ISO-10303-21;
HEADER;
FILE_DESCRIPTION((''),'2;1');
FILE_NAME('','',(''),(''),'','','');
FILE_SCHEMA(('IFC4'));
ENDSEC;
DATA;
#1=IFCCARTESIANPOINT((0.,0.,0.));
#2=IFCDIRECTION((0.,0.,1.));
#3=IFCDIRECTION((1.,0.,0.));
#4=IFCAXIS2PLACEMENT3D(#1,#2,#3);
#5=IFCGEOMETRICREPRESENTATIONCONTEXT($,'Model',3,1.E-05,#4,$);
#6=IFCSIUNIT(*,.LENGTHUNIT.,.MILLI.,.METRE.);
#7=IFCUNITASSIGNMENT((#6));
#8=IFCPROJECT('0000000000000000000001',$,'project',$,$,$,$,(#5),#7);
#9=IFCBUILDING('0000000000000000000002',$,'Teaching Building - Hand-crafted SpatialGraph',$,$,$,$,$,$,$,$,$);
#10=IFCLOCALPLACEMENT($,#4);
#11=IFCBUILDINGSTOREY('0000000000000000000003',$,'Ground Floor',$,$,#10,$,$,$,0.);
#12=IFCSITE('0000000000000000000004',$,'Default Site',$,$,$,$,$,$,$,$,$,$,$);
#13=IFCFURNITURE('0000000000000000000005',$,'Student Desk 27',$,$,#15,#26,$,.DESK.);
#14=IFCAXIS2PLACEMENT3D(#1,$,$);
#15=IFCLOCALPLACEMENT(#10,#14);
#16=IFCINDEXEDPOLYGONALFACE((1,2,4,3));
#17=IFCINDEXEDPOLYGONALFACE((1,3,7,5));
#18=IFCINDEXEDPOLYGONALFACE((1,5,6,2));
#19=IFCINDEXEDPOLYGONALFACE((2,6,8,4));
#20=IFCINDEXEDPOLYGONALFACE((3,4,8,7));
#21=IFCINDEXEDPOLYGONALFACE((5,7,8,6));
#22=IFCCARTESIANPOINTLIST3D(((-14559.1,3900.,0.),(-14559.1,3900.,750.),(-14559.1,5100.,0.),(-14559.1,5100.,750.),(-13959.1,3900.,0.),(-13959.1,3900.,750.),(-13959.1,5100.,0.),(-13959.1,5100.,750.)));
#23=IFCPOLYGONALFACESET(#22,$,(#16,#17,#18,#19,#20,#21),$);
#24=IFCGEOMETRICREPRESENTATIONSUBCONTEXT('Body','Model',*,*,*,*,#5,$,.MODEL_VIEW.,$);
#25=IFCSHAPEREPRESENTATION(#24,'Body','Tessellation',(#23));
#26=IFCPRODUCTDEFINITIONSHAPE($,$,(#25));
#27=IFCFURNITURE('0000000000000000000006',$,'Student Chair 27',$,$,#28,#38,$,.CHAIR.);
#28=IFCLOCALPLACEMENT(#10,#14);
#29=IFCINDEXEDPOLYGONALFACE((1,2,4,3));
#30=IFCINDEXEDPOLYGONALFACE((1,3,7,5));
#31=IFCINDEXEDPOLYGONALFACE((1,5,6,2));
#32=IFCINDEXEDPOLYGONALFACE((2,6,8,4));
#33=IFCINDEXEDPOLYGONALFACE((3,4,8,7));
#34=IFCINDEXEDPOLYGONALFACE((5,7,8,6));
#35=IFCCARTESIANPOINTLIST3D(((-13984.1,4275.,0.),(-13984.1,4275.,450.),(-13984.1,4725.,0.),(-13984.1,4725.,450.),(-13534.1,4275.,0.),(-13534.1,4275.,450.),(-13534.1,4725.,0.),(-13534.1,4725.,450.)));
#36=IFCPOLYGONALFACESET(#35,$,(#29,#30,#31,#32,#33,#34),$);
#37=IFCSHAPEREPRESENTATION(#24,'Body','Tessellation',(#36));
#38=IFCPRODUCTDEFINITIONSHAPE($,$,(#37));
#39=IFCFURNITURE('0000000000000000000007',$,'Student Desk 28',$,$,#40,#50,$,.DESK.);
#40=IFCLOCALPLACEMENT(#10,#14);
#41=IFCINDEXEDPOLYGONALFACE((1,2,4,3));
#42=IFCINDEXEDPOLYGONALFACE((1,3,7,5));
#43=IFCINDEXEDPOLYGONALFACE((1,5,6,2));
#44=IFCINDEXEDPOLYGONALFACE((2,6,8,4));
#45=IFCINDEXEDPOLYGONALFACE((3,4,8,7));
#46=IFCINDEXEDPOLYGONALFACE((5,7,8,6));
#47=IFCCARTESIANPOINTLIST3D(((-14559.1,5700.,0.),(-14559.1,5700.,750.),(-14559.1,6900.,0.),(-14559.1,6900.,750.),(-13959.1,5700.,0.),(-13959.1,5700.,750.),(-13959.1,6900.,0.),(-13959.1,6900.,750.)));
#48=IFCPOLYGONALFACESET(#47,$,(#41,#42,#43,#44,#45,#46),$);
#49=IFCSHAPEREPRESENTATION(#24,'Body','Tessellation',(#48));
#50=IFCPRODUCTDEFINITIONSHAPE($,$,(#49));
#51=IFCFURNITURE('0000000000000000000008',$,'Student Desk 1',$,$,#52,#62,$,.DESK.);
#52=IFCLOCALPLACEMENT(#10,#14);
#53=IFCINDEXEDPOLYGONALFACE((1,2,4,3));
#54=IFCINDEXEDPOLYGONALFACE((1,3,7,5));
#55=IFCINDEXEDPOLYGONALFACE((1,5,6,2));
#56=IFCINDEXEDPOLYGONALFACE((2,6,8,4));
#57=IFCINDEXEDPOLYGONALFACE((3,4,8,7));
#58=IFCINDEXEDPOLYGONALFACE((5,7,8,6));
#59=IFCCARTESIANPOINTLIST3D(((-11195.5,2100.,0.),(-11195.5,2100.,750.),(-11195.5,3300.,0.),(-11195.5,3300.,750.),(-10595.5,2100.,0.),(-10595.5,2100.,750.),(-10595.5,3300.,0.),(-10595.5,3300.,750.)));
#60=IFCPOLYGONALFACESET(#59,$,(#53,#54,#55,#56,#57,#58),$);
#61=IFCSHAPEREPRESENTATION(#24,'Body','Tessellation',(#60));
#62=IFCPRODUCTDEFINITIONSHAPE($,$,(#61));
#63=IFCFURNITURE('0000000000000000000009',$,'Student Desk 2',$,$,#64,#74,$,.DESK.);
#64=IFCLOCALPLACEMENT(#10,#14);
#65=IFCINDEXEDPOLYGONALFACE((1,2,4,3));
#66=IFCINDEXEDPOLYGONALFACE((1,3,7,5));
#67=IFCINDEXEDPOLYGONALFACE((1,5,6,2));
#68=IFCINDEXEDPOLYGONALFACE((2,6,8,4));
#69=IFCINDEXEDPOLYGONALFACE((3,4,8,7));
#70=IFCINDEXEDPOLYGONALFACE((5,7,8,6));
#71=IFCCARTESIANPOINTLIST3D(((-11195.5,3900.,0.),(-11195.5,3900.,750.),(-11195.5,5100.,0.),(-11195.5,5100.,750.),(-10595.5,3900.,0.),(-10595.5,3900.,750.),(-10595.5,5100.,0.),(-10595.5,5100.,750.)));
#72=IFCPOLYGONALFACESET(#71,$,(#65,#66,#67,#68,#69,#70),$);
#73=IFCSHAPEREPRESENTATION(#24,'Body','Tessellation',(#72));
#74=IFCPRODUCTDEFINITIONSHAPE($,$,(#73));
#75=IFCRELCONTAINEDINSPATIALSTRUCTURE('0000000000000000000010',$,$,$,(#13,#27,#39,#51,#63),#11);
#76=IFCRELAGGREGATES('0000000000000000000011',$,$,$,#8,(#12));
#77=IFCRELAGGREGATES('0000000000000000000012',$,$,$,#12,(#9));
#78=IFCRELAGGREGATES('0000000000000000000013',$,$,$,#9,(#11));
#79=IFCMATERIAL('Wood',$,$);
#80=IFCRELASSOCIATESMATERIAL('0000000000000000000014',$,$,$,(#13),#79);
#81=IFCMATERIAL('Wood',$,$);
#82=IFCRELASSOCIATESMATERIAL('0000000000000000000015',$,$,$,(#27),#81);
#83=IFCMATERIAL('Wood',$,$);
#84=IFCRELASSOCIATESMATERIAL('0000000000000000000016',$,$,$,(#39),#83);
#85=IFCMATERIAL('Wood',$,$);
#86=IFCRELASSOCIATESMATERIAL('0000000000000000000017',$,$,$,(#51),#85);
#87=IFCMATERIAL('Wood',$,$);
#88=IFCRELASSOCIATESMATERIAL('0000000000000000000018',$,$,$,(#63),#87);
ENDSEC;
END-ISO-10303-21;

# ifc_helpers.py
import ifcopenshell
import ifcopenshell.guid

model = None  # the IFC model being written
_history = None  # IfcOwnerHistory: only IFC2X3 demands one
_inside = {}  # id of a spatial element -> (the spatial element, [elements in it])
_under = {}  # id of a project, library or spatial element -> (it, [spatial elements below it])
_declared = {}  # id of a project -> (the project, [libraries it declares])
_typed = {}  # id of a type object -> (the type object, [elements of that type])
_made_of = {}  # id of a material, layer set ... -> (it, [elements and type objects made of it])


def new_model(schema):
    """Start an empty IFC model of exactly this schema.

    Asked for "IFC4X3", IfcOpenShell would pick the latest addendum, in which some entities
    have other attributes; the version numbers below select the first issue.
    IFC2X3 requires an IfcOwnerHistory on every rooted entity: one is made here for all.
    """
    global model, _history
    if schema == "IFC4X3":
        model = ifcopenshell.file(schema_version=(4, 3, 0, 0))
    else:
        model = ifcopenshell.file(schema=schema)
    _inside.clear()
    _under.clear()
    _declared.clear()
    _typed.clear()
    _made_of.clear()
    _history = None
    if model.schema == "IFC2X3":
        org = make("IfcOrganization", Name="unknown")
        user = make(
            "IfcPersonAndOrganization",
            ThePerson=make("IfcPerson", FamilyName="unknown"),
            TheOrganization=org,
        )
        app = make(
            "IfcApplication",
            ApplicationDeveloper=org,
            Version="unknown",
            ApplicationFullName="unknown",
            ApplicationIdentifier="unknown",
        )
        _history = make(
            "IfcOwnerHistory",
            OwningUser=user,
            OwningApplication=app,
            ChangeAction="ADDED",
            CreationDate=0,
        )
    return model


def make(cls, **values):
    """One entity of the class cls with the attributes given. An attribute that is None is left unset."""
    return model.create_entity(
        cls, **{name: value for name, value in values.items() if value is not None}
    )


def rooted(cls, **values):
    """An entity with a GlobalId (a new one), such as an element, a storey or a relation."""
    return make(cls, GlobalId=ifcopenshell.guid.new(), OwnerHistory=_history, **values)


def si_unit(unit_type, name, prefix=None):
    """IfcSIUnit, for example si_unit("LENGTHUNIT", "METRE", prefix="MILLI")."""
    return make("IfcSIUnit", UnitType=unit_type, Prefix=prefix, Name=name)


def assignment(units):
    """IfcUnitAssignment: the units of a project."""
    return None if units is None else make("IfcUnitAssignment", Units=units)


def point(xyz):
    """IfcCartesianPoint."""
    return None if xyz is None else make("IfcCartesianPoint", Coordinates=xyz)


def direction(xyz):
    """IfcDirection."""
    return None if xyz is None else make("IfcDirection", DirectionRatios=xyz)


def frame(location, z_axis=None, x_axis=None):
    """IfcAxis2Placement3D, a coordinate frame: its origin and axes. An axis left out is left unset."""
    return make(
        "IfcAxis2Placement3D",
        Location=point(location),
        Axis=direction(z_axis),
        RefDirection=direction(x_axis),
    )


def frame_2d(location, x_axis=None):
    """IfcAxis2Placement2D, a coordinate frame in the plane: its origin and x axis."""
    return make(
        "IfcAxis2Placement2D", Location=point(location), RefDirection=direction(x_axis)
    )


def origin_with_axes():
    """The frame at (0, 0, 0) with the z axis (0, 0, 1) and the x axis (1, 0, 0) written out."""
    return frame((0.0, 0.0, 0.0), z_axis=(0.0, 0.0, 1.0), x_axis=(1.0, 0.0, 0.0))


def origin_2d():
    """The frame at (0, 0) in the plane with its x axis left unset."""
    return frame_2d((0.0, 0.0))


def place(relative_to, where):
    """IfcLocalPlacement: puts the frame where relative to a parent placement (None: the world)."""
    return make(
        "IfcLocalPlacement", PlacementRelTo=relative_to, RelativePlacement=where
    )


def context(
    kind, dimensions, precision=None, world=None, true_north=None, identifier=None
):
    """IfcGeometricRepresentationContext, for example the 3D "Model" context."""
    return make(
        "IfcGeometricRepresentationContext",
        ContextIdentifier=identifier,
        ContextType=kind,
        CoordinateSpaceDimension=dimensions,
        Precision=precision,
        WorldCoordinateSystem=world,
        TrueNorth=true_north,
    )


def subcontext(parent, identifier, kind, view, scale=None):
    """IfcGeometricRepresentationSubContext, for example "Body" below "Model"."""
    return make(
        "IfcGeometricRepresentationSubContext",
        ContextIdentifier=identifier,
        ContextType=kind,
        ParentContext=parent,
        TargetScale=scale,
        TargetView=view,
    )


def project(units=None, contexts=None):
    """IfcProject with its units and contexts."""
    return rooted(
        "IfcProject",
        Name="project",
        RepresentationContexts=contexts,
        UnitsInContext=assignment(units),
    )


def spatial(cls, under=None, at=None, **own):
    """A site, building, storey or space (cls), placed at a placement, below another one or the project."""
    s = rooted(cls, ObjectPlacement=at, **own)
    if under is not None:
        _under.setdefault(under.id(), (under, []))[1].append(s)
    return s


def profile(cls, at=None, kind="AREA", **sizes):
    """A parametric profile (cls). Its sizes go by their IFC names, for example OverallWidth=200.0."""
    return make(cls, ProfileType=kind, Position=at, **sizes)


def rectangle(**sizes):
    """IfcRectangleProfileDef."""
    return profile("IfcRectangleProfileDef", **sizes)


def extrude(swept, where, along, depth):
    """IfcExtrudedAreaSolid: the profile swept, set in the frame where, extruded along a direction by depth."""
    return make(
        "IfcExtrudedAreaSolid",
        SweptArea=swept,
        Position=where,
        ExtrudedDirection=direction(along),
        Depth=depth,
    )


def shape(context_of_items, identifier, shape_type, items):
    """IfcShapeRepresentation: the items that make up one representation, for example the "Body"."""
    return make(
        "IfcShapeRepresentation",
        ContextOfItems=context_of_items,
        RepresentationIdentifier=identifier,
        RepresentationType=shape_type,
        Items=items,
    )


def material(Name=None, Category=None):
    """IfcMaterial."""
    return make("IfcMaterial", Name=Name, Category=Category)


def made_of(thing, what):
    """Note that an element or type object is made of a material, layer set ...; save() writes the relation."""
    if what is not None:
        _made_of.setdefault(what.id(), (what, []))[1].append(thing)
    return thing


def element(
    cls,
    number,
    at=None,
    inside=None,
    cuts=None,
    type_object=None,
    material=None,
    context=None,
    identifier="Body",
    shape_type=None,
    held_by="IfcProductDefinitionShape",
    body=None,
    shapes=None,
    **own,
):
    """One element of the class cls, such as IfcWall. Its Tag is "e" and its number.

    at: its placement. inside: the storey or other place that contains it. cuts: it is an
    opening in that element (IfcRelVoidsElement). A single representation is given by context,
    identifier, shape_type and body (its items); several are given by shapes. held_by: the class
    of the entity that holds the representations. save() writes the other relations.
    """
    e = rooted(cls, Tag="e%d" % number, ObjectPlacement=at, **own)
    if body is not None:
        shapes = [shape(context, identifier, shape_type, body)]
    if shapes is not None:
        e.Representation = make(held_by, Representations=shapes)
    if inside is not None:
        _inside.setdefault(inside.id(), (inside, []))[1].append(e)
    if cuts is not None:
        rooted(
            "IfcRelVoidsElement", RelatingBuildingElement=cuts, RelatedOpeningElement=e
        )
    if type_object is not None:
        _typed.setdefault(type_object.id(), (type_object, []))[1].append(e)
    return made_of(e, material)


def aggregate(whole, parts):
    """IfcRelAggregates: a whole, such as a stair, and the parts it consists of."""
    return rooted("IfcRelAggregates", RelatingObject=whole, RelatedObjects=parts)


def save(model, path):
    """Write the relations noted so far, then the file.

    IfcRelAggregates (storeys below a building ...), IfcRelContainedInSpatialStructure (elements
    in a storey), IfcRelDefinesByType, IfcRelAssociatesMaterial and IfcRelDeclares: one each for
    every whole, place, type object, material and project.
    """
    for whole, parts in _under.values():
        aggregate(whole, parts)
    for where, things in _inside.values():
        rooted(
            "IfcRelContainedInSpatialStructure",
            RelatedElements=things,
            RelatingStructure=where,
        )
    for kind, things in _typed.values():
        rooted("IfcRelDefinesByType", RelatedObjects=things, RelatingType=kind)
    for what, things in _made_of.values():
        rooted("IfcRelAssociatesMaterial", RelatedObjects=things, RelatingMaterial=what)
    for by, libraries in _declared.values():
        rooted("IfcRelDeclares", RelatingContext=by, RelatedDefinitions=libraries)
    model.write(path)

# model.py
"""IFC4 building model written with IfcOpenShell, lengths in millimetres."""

from ifc_helpers import new_model, si_unit, frame, origin_with_axes, origin_2d, place, context, subcontext, project, spatial, rectangle, extrude, material, element, save


model = new_model("IFC4")

# Units and contexts
model_context = context("Model", 3, precision=1e-05, world=origin_with_axes())
body_context = subcontext(model_context, "Body", "Model", "MODEL_VIEW")
ifc_project = project(units=[si_unit("LENGTHUNIT", "METRE", prefix="MILLI")], contexts=[model_context])

# Site, building, storey
site = spatial("IfcSite", under=ifc_project, Name="Default Site")
building = spatial("IfcBuilding", under=site, Name="Teaching Building - Hand-crafted SpatialGraph")
storey_placement = place(None, origin_with_axes())
storey = spatial("IfcBuildingStorey", under=building, at=storey_placement, Name="Ground Floor", Elevation=0.0)

# Furniture
ifc_material_1 = material(Name="Wood")
furniture_1_placement = place(storey_placement, frame((-14259.1, 4500.0, 0.0), z_axis=(0.0, 0.0, 1.0), x_axis=(0.0, 1.0, 0.0)))
element("IfcFurniture", 1, at=furniture_1_placement, inside=storey, material=ifc_material_1, Name="Student Desk 27", PredefinedType="DESK", context=body_context, shape_type="SweptSolid", body=[
    extrude(rectangle(XDim=1200.0, YDim=600.0, at=origin_2d()), origin_with_axes(), (0.0, 0.0, 1.0), 750.0),
])
ifc_material_2 = material(Name="Wood")
furniture_2_placement = place(storey_placement, frame((-13759.1, 4500.0, 0.0), z_axis=(0.0, 0.0, 1.0), x_axis=(1.0, 0.0, 0.0)))
element("IfcFurniture", 2, at=furniture_2_placement, inside=storey, material=ifc_material_2, Name="Student Chair 27", PredefinedType="CHAIR", context=body_context, shape_type="SweptSolid", body=[
    extrude(rectangle(XDim=450.0, YDim=450.0, at=origin_2d()), origin_with_axes(), (0.0, 0.0, 1.0), 450.0),
])
ifc_material_3 = material(Name="Wood")
furniture_3_placement = place(storey_placement, frame((-14259.1, 6300.0, 0.0), z_axis=(0.0, 0.0, 1.0), x_axis=(0.0, 1.0, 0.0)))
element("IfcFurniture", 3, at=furniture_3_placement, inside=storey, material=ifc_material_3, Name="Student Desk 28", PredefinedType="DESK", context=body_context, shape_type="SweptSolid", body=[
    extrude(rectangle(XDim=1200.0, YDim=600.0, at=origin_2d()), origin_with_axes(), (0.0, 0.0, 1.0), 750.0),
])
ifc_material_4 = material(Name="Wood")
furniture_4_placement = place(storey_placement, frame((-10895.5, 2700.0, 0.0), z_axis=(0.0, 0.0, 1.0), x_axis=(0.0, 1.0, 0.0)))
element("IfcFurniture", 4, at=furniture_4_placement, inside=storey, material=ifc_material_4, Name="Student Desk 1", PredefinedType="DESK", context=body_context, shape_type="SweptSolid", body=[
    extrude(rectangle(XDim=1200.0, YDim=600.0, at=origin_2d()), origin_with_axes(), (0.0, 0.0, 1.0), 750.0),
])
ifc_material_5 = material(Name="Wood")
furniture_5_placement = place(storey_placement, frame((-10895.5, 4500.0, 0.0), z_axis=(0.0, 0.0, 1.0), x_axis=(0.0, 1.0, 0.0)))
element("IfcFurniture", 5, at=furniture_5_placement, inside=storey, material=ifc_material_5, Name="Student Desk 2", PredefinedType="DESK", context=body_context, shape_type="SweptSolid", body=[
    extrude(rectangle(XDim=1200.0, YDim=600.0, at=origin_2d()), origin_with_axes(), (0.0, 0.0, 1.0), 750.0),
])

save(model, "model.ifc")
